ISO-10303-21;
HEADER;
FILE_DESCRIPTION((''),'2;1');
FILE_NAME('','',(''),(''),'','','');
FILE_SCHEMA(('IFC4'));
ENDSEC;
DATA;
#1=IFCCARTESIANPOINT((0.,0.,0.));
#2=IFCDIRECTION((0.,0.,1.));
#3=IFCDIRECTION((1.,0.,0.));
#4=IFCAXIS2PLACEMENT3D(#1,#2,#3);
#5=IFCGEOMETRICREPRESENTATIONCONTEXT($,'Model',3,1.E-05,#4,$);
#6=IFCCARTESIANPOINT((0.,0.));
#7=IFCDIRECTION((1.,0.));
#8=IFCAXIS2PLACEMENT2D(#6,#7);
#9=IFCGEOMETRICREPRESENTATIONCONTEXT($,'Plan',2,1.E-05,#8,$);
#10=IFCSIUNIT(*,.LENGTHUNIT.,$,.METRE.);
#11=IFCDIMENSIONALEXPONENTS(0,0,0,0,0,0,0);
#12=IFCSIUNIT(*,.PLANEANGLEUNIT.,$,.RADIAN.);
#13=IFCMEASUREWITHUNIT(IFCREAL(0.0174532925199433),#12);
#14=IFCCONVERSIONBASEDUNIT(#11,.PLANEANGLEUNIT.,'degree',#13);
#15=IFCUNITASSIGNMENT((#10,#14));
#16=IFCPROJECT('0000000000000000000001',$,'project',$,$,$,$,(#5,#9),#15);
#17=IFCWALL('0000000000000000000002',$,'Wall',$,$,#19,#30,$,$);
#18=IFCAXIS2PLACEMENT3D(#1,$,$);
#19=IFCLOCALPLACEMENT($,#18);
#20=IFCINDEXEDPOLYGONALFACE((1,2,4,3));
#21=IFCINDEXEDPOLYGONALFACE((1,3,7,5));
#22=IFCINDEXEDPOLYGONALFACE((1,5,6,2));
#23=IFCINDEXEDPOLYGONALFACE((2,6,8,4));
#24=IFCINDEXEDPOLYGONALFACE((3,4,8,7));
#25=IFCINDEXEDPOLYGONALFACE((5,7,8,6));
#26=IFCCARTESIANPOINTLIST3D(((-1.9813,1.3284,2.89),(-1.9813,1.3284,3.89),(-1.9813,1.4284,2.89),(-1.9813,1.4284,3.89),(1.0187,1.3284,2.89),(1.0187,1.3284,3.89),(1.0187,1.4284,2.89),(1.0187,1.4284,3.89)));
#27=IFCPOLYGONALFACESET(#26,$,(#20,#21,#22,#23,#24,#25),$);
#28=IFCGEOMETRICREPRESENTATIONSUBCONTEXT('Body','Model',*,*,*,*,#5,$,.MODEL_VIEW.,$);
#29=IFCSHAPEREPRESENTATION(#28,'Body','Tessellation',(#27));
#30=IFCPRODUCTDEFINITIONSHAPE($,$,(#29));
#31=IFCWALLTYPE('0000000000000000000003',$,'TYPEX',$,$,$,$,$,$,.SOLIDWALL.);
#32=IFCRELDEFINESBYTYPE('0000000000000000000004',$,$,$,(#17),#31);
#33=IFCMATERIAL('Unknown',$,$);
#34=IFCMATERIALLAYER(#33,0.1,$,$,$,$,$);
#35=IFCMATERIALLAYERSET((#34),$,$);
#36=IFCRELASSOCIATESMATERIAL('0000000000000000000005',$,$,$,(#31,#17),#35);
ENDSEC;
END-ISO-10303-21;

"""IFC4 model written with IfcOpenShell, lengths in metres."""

from ifc_helpers import new_model, entity, si_unit, converted_unit, frame, origin_with_axes, origin_2d_with_axis, place, context, subcontext, project, indexed_curve, outline, extrude, material, layer, layer_set, layer_usage, type_object, element, save


model = new_model("IFC4")

# Units and contexts
model_context = context("Model", 3, precision=1e-05, world=origin_with_axes())
plan_context = context("Plan", 2, precision=1e-05, world=origin_2d_with_axis())
body_context = subcontext(model_context, "Body", "Model", "MODEL_VIEW")
ifc_project = project(units=[si_unit("LENGTHUNIT", "METRE"), converted_unit("PLANEANGLEUNIT", "degree", entity("IfcReal", 0.0174532925199433), si_unit("PLANEANGLEUNIT", "RADIAN"), dimensions=[0, 0, 0, 0, 0, 0, 0])], contexts=[model_context, plan_context])

# Wall
ifc_material = material(Name="Unknown")
ifc_layer = layer(ifc_material, 0.1)
ifc_layer_set = layer_set([ifc_layer])
ifc_layer_usage = layer_usage(ifc_layer_set, "AXIS2", "POSITIVE", 0.0)
wall_type = type_object("IfcWallType", Name="TYPEX", PredefinedType="SOLIDWALL", material=ifc_layer_set)
wall_placement = place(None, frame((-1.9813, 1.3284, 2.89), z_axis=(0.0, 0.0, 1.0), x_axis=(1.0, 0.0, 0.0)))
element("IfcWall", 1, at=wall_placement, type_object=wall_type, material=ifc_layer_usage, Name="Wall", context=body_context, shape_type="SweptSolid", body=[
    extrude(outline(indexed_curve([(0.0, 0.0), (0.0, 0.1), (3.0, 0.1), (3.0, 0.0), (0.0, 0.0)], self_intersect=False)), origin_with_axes(), (0.0, 0.0, 1.0), 1.0),
])

save(model, "model.ifc")
